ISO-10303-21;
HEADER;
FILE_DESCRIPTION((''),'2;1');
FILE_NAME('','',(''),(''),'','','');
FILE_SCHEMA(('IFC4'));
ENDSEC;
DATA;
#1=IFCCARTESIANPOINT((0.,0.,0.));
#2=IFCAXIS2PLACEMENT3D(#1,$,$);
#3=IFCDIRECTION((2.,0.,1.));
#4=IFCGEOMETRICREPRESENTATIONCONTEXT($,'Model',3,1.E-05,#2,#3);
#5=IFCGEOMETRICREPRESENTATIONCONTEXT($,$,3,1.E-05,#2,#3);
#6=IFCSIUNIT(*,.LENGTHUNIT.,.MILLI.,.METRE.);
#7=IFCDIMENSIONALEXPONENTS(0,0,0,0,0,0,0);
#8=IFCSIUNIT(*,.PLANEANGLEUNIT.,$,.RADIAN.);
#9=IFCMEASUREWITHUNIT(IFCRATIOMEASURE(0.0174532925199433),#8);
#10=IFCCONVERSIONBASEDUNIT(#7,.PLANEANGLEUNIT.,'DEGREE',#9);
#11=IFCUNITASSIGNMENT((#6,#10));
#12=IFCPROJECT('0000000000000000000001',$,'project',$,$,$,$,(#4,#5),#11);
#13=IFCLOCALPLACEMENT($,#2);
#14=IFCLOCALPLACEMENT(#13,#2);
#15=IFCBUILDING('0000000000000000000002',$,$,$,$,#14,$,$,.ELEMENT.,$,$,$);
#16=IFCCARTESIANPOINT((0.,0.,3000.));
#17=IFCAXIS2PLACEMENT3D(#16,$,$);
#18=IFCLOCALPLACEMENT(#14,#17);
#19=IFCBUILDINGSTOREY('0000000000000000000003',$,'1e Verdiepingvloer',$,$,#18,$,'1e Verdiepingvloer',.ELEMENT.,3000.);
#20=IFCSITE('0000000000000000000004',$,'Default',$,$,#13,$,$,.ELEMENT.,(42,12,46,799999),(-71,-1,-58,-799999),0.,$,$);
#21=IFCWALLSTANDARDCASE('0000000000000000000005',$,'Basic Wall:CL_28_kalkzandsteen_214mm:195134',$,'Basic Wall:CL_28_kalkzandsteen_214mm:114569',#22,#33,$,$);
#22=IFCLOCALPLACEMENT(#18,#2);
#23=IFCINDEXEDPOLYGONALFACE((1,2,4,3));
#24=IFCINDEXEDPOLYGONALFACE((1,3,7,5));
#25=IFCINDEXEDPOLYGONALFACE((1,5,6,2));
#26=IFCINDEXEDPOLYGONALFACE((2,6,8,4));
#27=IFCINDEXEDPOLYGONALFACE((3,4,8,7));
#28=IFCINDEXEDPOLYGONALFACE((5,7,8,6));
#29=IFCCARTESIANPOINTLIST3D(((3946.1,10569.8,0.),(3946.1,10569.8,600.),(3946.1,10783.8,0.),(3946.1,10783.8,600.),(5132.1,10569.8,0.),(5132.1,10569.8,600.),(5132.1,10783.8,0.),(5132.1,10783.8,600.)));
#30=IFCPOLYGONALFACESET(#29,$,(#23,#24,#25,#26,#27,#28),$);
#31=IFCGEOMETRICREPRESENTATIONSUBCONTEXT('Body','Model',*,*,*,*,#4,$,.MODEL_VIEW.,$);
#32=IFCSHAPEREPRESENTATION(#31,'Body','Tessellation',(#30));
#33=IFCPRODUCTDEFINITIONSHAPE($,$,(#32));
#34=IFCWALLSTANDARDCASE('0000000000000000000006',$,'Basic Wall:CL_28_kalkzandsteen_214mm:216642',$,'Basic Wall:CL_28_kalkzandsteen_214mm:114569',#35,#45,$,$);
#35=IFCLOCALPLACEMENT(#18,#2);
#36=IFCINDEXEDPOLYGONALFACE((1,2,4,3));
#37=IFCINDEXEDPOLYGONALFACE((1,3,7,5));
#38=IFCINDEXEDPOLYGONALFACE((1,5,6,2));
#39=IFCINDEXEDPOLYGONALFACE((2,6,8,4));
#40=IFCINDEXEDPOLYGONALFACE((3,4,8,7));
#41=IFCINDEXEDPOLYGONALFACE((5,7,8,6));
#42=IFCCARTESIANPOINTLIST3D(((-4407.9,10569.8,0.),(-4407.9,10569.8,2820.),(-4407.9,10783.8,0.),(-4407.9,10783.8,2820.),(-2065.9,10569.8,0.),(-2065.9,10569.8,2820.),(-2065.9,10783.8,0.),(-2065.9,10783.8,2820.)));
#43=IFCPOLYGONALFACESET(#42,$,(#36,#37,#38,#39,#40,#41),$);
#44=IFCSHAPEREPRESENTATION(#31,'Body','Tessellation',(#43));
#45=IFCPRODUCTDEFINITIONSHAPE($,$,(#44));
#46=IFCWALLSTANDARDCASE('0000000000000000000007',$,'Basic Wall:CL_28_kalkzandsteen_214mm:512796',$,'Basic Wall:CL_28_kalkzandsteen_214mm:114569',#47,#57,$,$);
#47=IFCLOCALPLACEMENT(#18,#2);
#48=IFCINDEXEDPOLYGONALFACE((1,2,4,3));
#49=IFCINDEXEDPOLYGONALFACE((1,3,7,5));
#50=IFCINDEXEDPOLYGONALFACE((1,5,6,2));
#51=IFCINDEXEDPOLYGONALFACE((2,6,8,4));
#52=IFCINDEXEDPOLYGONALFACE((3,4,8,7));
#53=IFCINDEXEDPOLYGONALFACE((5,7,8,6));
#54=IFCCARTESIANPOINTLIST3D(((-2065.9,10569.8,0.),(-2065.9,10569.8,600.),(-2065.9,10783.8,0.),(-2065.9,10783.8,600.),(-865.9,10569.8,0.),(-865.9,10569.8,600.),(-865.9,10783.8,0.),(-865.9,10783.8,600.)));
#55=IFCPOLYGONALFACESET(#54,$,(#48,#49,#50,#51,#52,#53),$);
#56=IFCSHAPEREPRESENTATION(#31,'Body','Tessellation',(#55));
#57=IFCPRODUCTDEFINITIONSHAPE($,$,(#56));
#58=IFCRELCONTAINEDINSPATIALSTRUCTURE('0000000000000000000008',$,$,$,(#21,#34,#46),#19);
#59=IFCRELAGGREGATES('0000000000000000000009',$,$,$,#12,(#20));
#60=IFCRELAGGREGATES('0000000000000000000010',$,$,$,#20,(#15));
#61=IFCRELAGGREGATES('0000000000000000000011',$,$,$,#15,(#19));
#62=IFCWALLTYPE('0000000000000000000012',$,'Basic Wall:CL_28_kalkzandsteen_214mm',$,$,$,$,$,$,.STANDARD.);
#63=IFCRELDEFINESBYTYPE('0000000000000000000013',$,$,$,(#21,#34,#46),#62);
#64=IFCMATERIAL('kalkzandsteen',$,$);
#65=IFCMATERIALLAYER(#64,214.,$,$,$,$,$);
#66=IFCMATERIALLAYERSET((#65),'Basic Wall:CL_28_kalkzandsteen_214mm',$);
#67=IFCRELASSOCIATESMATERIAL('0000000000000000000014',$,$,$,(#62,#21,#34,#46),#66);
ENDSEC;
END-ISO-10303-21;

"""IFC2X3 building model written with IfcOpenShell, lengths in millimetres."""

from ifc_helpers import new_model, entity, si_unit, converted_unit, direction, frame, frame_2d, origin, place, context, subcontext, project, spatial, rectangle, extrude, material, layer, layer_set, layer_usage, type_object, element, save


model = new_model("IFC2X3")

# Units and contexts
model_context = context("Model", 3, precision=1e-05, world=origin(), true_north=direction((2.0, 0.0, 1.0)))
context_of_model = context(None, 3, precision=1e-05, world=origin(), true_north=direction((2.0, 0.0, 1.0)))
body_context = subcontext(model_context, "Body", "Model", "MODEL_VIEW")
ifc_project = project(units=[si_unit("LENGTHUNIT", "METRE", prefix="MILLI"), converted_unit("PLANEANGLEUNIT", "DEGREE", entity("IfcRatioMeasure", 0.0174532925199433), si_unit("PLANEANGLEUNIT", "RADIAN"), dimensions=[0, 0, 0, 0, 0, 0, 0])], contexts=[model_context, context_of_model])

# Site, building, storey
site_placement = place(None, origin())
site = spatial("IfcSite", under=ifc_project, at=site_placement, Name="Default", CompositionType="ELEMENT", RefLatitude=(42, 12, 46, 799999), RefLongitude=(-71, -1, -58, -799999), RefElevation=0.0)
building_placement = place(site_placement, origin())
building = spatial("IfcBuilding", under=site, at=building_placement, CompositionType="ELEMENT")
storey_placement = place(building_placement, frame((0.0, 0.0, 3000.0)))
storey = spatial("IfcBuildingStorey", under=building, at=storey_placement, Name="1e Verdiepingvloer", LongName="1e Verdiepingvloer", CompositionType="ELEMENT", Elevation=3000.0)

# Walls
ifc_material_1 = material(Name="kalkzandsteen")
ifc_layer = layer(ifc_material_1, 214.0)
ifc_layer_set = layer_set([ifc_layer], Name="Basic Wall:CL_28_kalkzandsteen_214mm")
wall_type = type_object("IfcWallType", Name="Basic Wall:CL_28_kalkzandsteen_214mm", PredefinedType="STANDARD", material=ifc_layer_set)
ifc_layer_usage_1 = layer_usage(ifc_layer_set, "AXIS2", "NEGATIVE", 107.0)
wall_1_placement = place(storey_placement, frame((5132.1, 10676.8, 0.0), z_axis=(0.0, 0.0, 1.0), x_axis=(-1.0, 0.0, 0.0)))
element("IfcWallStandardCase", 1, at=wall_1_placement, inside=storey, type_object=wall_type, material=ifc_layer_usage_1, Name="Basic Wall:CL_28_kalkzandsteen_214mm:195134", ObjectType="Basic Wall:CL_28_kalkzandsteen_214mm:114569", context=body_context, shape_type="SweptSolid", body=[
    extrude(rectangle(XDim=1186.0, YDim=214.0, at=frame_2d((593.0, 0.0), x_axis=(-1.0, 0.0))), origin(), (0.0, 0.0, 1.0), 600.0),
])
ifc_layer_usage_2 = layer_usage(ifc_layer_set, "AXIS2", "NEGATIVE", 107.0)
wall_2_placement = place(storey_placement, frame((-2065.9, 10676.8, 0.0), z_axis=(0.0, 0.0, 1.0), x_axis=(-1.0, 0.0, 0.0)))
element("IfcWallStandardCase", 2, at=wall_2_placement, inside=storey, type_object=wall_type, material=ifc_layer_usage_2, Name="Basic Wall:CL_28_kalkzandsteen_214mm:216642", ObjectType="Basic Wall:CL_28_kalkzandsteen_214mm:114569", context=body_context, shape_type="SweptSolid", body=[
    extrude(rectangle(XDim=2342.0, YDim=214.0, at=frame_2d((1171.0, 0.0), x_axis=(-1.0, 0.0))), origin(), (0.0, 0.0, 1.0), 2820.0),
])
ifc_layer_usage_3 = layer_usage(ifc_layer_set, "AXIS2", "NEGATIVE", 107.0)
wall_3_placement = place(storey_placement, frame((-865.9, 10676.8, 0.0), z_axis=(0.0, 0.0, 1.0), x_axis=(-1.0, 0.0, 0.0)))
element("IfcWallStandardCase", 3, at=wall_3_placement, inside=storey, type_object=wall_type, material=ifc_layer_usage_3, Name="Basic Wall:CL_28_kalkzandsteen_214mm:512796", ObjectType="Basic Wall:CL_28_kalkzandsteen_214mm:114569", context=body_context, shape_type="SweptSolid", body=[
    extrude(rectangle(XDim=1200.0, YDim=214.0, at=frame_2d((600.0, 0.0), x_axis=(-1.0, 0.0))), origin(), (0.0, 0.0, 1.0), 600.0),
])

save(model, "model.ifc")
